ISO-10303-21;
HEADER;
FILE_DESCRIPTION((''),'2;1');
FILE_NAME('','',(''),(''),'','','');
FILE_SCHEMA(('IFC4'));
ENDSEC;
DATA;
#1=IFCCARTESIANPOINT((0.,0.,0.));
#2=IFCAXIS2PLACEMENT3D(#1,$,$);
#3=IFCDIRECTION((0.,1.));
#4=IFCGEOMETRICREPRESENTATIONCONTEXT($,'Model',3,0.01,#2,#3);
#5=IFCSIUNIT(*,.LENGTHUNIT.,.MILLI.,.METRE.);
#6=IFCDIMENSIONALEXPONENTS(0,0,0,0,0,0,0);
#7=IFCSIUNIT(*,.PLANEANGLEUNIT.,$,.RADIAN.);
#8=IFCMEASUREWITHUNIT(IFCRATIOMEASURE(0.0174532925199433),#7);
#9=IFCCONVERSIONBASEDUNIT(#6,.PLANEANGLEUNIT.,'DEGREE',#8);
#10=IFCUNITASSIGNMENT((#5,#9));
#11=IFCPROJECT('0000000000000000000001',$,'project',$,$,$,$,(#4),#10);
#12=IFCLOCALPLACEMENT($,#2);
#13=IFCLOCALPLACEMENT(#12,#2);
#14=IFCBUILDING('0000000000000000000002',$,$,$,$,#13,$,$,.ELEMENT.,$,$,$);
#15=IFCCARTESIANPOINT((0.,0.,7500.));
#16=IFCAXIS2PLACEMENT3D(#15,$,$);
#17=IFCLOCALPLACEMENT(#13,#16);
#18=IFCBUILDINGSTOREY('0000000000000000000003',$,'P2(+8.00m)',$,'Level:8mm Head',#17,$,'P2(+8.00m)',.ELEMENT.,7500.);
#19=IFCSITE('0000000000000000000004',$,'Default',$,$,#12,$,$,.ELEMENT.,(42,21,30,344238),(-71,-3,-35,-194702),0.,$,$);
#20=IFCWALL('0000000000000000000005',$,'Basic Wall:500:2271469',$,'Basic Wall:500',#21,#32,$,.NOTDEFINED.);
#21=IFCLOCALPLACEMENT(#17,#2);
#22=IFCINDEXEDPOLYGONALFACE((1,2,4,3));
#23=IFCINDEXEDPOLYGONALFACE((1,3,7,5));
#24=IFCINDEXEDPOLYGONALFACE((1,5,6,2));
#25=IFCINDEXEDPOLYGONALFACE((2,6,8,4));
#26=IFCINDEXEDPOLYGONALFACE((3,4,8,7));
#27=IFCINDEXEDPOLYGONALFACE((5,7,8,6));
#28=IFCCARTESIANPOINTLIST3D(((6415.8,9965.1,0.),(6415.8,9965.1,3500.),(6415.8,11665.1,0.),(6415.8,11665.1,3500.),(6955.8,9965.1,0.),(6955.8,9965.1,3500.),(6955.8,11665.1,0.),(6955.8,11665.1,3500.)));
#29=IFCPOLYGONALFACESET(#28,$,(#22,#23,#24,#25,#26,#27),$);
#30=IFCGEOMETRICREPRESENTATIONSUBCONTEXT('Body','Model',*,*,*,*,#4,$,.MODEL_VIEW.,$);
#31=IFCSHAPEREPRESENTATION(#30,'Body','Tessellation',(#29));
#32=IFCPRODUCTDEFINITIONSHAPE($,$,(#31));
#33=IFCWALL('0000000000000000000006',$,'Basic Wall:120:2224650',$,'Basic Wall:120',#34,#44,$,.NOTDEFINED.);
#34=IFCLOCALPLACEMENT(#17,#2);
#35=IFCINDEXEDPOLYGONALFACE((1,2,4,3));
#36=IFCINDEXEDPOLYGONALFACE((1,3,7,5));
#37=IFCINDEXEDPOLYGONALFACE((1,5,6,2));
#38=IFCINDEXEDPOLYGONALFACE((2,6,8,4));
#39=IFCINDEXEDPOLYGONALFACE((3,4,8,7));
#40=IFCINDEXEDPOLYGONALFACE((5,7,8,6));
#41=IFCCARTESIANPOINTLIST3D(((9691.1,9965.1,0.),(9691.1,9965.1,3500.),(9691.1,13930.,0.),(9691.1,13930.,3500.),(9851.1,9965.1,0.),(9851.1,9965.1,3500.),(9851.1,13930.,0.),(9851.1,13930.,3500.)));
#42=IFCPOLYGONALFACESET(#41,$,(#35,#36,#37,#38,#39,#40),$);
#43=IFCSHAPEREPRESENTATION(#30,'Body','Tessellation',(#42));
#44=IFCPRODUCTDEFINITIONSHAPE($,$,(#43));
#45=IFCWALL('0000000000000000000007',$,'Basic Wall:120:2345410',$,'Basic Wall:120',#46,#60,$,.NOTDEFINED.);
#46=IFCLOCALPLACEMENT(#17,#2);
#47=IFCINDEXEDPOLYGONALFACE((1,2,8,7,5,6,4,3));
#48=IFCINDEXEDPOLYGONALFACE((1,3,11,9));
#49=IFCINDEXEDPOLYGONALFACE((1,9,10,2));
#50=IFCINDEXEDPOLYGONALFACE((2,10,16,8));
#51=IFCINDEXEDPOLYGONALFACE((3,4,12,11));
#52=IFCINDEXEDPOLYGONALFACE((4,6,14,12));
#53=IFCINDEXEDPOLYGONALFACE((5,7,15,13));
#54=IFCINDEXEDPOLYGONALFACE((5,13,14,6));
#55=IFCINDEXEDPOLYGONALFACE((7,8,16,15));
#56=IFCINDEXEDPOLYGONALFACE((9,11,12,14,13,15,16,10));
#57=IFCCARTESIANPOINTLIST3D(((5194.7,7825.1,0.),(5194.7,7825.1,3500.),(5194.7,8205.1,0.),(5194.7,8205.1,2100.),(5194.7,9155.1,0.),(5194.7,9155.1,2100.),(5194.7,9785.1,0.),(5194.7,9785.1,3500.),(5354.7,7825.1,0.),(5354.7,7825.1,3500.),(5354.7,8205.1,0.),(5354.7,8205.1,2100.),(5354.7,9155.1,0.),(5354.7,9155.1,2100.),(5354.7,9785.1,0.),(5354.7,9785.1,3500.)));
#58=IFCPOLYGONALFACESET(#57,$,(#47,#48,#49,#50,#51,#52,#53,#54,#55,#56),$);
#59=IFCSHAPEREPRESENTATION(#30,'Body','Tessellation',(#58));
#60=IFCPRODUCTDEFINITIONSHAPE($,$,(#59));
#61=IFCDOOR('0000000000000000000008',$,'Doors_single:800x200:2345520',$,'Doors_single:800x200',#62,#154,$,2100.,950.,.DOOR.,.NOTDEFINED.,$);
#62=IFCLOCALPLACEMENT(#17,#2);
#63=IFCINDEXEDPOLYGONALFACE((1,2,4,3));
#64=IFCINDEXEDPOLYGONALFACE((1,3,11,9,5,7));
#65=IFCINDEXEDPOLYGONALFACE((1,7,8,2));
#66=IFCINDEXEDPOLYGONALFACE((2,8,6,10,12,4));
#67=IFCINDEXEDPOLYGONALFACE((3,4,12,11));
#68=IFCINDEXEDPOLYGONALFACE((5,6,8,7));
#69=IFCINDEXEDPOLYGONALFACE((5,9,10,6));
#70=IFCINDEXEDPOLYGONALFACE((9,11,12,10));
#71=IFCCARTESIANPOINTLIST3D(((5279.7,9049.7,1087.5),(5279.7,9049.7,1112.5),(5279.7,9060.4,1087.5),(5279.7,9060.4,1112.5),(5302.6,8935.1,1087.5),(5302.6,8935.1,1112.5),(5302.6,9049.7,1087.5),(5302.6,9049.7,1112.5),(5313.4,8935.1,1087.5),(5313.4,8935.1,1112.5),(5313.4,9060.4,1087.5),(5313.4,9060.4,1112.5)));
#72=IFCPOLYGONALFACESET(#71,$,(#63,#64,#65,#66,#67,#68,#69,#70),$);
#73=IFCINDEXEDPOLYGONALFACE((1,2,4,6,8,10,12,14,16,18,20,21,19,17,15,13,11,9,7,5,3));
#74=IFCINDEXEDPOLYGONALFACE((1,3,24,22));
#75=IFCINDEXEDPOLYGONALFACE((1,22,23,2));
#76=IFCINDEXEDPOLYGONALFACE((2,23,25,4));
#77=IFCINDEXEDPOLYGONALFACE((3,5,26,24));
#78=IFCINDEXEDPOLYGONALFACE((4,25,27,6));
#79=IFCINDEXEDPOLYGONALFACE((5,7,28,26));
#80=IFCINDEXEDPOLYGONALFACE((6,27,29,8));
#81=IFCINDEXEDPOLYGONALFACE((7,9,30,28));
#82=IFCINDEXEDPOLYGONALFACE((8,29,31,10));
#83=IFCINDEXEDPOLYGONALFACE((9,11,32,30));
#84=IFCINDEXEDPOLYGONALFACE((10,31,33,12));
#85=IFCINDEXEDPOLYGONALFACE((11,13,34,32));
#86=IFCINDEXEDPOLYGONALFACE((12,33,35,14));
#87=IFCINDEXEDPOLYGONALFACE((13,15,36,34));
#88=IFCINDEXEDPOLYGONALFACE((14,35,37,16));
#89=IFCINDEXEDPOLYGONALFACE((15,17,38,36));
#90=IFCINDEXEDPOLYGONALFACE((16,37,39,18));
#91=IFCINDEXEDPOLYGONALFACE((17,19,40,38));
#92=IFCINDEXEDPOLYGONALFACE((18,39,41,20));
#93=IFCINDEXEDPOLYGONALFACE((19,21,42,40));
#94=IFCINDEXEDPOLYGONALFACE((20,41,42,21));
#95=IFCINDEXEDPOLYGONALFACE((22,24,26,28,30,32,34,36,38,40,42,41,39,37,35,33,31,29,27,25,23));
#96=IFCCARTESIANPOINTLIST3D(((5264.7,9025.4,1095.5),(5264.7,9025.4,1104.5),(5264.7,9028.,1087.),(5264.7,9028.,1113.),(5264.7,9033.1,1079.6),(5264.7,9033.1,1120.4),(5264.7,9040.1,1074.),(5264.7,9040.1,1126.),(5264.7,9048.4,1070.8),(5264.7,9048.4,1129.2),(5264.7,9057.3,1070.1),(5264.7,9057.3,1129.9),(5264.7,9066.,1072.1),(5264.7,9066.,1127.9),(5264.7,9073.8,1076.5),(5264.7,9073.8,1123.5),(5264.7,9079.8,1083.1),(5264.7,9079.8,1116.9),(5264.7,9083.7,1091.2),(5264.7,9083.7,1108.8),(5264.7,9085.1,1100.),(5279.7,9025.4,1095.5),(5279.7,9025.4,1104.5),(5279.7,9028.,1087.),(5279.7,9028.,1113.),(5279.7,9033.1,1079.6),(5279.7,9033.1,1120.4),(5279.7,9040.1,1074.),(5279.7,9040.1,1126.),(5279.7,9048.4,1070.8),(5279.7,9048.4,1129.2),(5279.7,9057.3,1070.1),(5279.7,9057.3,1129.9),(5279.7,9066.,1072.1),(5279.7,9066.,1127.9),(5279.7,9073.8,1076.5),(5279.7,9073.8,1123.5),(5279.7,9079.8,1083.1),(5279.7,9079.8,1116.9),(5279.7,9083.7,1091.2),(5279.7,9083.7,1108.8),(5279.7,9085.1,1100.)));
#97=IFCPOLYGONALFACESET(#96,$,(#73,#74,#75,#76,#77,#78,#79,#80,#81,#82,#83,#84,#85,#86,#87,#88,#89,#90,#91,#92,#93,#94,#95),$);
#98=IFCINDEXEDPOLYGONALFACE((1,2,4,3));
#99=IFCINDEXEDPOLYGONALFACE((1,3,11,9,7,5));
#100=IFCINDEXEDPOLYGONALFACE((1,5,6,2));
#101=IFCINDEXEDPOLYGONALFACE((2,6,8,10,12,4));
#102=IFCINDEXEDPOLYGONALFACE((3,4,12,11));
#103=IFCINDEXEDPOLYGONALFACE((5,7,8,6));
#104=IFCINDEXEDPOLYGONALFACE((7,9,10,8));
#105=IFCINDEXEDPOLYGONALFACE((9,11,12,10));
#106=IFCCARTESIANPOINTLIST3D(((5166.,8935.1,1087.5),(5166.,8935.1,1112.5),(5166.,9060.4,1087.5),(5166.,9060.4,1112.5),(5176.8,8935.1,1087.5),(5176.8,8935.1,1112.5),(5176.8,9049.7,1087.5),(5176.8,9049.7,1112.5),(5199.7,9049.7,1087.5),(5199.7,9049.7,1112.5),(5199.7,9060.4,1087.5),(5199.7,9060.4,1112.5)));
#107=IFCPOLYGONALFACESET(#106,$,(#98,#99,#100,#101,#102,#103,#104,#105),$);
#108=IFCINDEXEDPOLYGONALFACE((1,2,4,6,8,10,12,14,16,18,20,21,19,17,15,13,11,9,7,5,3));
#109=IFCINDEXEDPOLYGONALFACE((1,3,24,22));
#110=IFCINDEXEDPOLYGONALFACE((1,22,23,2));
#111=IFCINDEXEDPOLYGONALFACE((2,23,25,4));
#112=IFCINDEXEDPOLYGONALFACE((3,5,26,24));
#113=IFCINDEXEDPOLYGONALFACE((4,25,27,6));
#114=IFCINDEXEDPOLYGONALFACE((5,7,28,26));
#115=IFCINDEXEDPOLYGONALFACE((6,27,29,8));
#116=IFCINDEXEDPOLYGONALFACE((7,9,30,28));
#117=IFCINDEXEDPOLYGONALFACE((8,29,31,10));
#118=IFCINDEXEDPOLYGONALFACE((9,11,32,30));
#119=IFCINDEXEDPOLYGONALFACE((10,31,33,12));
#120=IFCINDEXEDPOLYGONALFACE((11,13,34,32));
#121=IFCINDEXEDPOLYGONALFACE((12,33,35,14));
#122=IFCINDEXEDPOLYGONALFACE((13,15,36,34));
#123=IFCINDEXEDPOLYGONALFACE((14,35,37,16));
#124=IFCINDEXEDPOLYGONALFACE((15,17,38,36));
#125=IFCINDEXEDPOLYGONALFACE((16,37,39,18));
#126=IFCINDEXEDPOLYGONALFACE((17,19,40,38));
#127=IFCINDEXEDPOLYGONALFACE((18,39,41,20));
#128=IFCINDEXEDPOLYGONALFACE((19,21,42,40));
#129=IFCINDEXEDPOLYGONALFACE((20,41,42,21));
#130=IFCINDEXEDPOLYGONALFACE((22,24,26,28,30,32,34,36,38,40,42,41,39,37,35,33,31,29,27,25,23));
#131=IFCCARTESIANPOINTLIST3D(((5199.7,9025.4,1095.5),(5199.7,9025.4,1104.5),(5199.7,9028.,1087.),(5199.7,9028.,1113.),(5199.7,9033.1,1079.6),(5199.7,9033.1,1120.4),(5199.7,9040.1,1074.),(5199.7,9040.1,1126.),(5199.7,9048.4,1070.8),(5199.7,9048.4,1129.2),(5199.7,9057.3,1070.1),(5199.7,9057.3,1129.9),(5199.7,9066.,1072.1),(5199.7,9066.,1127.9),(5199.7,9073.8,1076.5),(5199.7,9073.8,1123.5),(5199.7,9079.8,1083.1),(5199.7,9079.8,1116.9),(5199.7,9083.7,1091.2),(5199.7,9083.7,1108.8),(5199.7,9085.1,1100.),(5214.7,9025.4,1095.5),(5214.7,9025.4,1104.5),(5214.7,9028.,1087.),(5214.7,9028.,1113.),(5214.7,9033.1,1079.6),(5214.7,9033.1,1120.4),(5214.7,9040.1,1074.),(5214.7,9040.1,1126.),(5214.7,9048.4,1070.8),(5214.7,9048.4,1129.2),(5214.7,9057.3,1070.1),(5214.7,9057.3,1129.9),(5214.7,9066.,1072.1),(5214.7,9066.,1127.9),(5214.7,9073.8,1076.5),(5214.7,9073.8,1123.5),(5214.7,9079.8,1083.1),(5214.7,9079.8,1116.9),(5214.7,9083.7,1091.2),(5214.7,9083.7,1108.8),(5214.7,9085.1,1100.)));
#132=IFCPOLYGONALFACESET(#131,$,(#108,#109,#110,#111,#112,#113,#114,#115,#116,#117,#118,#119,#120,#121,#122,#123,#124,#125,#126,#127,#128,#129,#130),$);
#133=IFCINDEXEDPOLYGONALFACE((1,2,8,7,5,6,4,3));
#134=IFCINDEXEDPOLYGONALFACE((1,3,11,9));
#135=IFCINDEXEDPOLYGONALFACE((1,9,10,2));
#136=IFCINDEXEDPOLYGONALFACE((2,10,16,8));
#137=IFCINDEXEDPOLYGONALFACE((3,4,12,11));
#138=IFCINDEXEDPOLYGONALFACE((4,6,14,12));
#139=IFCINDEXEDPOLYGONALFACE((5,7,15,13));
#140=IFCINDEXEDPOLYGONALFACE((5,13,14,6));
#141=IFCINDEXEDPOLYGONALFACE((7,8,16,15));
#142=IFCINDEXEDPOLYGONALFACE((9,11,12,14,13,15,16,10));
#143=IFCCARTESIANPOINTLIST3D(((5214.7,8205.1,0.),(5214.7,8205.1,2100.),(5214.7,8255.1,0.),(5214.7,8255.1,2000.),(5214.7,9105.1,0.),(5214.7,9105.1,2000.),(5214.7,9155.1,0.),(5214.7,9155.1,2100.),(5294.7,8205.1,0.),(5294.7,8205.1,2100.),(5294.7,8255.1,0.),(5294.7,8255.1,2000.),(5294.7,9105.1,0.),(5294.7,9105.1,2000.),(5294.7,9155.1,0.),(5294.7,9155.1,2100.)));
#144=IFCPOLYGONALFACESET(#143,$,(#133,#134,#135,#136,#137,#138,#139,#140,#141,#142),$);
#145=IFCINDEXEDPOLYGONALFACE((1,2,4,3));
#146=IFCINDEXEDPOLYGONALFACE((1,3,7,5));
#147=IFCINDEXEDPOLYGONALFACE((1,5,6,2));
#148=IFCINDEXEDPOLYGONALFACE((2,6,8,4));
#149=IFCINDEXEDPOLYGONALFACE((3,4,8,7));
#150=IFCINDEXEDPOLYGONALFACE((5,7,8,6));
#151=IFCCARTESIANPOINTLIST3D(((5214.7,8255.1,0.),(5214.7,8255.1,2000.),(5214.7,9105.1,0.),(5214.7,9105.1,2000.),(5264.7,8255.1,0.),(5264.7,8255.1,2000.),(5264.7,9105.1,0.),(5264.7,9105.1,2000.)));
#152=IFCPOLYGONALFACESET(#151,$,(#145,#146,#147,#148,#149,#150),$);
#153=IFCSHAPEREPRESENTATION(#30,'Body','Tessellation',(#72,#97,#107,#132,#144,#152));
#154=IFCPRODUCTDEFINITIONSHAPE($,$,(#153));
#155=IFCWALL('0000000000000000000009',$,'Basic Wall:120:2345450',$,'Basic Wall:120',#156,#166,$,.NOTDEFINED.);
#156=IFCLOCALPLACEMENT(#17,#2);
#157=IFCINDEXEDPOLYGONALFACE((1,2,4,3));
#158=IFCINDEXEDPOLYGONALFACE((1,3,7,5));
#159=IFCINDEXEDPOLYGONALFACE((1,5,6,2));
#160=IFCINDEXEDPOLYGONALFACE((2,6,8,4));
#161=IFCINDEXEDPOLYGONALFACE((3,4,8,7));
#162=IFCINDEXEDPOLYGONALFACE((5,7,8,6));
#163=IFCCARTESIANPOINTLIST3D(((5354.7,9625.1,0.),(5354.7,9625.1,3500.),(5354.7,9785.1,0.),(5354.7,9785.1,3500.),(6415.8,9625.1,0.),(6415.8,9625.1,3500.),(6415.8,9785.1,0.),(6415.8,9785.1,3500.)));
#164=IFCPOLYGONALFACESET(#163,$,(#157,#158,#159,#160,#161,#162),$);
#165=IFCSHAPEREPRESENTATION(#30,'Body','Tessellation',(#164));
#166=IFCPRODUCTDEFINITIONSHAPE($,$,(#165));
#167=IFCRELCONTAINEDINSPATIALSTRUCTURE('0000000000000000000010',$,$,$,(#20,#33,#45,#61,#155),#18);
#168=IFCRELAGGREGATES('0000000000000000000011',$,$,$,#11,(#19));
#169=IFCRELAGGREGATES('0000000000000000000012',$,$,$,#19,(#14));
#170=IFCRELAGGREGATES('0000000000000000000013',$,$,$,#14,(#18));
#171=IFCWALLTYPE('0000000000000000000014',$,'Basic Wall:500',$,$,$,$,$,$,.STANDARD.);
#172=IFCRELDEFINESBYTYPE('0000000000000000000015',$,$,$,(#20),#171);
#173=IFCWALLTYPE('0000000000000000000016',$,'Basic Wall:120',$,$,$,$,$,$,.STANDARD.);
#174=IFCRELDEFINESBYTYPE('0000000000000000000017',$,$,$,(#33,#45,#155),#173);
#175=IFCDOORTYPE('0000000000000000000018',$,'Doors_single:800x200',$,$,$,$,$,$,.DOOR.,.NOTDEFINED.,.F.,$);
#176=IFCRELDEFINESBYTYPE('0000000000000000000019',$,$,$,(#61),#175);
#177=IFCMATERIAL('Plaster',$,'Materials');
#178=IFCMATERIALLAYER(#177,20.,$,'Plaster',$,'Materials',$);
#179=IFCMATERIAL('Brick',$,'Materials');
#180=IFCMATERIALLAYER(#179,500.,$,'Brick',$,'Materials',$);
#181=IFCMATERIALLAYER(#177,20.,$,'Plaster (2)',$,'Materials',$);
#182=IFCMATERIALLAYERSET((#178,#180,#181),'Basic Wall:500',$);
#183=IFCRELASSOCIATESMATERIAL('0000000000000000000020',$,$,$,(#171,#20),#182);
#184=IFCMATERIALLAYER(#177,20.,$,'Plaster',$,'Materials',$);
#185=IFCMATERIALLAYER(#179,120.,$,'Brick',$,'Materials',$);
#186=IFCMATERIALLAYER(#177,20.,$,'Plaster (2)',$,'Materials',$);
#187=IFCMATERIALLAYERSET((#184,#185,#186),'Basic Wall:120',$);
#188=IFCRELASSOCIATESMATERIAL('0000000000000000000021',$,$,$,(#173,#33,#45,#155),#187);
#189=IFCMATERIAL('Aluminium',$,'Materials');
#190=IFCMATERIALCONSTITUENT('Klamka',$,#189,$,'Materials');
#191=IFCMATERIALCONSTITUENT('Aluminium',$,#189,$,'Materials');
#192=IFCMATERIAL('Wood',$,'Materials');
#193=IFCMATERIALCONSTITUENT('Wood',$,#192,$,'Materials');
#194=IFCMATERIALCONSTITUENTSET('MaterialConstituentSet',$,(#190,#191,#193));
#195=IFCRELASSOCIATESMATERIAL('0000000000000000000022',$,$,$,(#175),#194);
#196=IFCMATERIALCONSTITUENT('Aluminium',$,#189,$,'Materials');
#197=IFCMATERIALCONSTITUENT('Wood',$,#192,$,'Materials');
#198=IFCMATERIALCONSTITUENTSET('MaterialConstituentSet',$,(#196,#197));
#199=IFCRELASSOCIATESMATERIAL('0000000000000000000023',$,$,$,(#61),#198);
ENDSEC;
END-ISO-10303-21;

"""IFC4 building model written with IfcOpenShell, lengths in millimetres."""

from ifc_helpers import new_model, entity, si_unit, converted_unit, direction, frame, frame_2d, origin, origin_2d_with_axis, place, context, subcontext, project, spatial, polyline, rectangle, circle, outline, extrude, source, transform, mapped, material, layer, layer_set, layer_usage, constituent, constituent_set, type_object, type_shapes, element, fill, save


model = new_model("IFC4")

# Units and contexts
model_context = context("Model", 3, precision=0.01, world=origin(), true_north=direction((0.0, 1.0)))
body_context = subcontext(model_context, "Body", "Model", "MODEL_VIEW")
ifc_project = project(units=[si_unit("LENGTHUNIT", "METRE", prefix="MILLI"), converted_unit("PLANEANGLEUNIT", "DEGREE", entity("IfcRatioMeasure", 0.0174532925199433), si_unit("PLANEANGLEUNIT", "RADIAN"), dimensions=[0, 0, 0, 0, 0, 0, 0])], contexts=[model_context])

# Site, building, storey
site_placement = place(None, origin())
site = spatial("IfcSite", under=ifc_project, at=site_placement, Name="Default", CompositionType="ELEMENT", RefLatitude=(42, 21, 30, 344238), RefLongitude=(-71, -3, -35, -194702), RefElevation=0.0)
building_placement = place(site_placement, origin())
building = spatial("IfcBuilding", under=site, at=building_placement, CompositionType="ELEMENT")
storey_placement = place(building_placement, frame((0.0, 0.0, 7500.0)))
storey = spatial("IfcBuildingStorey", under=building, at=storey_placement, Name="P2(+8.00m)", ObjectType="Level:8mm Head", LongName="P2(+8.00m)", CompositionType="ELEMENT", Elevation=7500.0)

# Shared definitions
ifc_material_1 = material(Name="Brick", Category="Materials")
ifc_material_2 = material(Name="Plaster", Category="Materials")

# Shared definitions
ifc_layer_1 = layer(ifc_material_2, 20.0, Name="Plaster", Category="Materials")
ifc_layer_2 = layer(ifc_material_1, 500.0, Name="Brick", Category="Materials")
ifc_layer_3 = layer(ifc_material_2, 20.0, Name="Plaster (2)", Category="Materials")
ifc_layer_set_1 = layer_set([ifc_layer_1, ifc_layer_2, ifc_layer_3], Name="Basic Wall:500")
wall_type_1 = type_object("IfcWallType", Name="Basic Wall:500", PredefinedType="STANDARD", material=ifc_layer_set_1)
ifc_material_3 = material(Name="Aluminium", Category="Materials")
ifc_material_4 = material(Name="Wood", Category="Materials")

# Walls
ifc_layer_usage_1 = layer_usage(ifc_layer_set_1, "AXIS2", "POSITIVE", -270.0)
wall_1_placement = place(storey_placement, frame((6685.8, 11665.1, 0.0), z_axis=(0.0, 0.0, 1.0), x_axis=(0.0, -1.0, 0.0)))
element("IfcWall", 1, at=wall_1_placement, inside=storey, type_object=wall_type_1, material=ifc_layer_usage_1, Name="Basic Wall:500:2271469", ObjectType="Basic Wall:500", PredefinedType="NOTDEFINED", context=body_context, shape_type="SweptSolid", body=[
    extrude(rectangle(XDim=1700.0, YDim=540.0, at=frame_2d((850.0, 0.0), x_axis=(-1.0, 0.0))), origin(), (0.0, 0.0, 1.0), 3500.0),
])
ifc_layer_4 = layer(ifc_material_2, 20.0, Name="Plaster", Category="Materials")
ifc_layer_5 = layer(ifc_material_1, 120.0, Name="Brick", Category="Materials")
ifc_layer_6 = layer(ifc_material_2, 20.0, Name="Plaster (2)", Category="Materials")
ifc_layer_set_2 = layer_set([ifc_layer_4, ifc_layer_5, ifc_layer_6], Name="Basic Wall:120")
ifc_layer_usage_2 = layer_usage(ifc_layer_set_2, "AXIS2", "POSITIVE", -80.0)
wall_type_2 = type_object("IfcWallType", Name="Basic Wall:120", PredefinedType="STANDARD", material=ifc_layer_set_2)
wall_2_placement = place(storey_placement, frame((9771.1, 9965.1, 0.0), z_axis=(0.0, 0.0, 1.0), x_axis=(0.0, 1.0, 0.0)))
element("IfcWall", 2, at=wall_2_placement, inside=storey, type_object=wall_type_2, material=ifc_layer_usage_2, Name="Basic Wall:120:2224650", ObjectType="Basic Wall:120", PredefinedType="NOTDEFINED", context=body_context, shape_type="SweptSolid", body=[
    extrude(rectangle(XDim=3964.9, YDim=160.0, at=frame_2d((1982.5, 0.0), x_axis=(-1.0, 0.0))), origin(), (0.0, 0.0, 1.0), 3500.0),
])

# Wall, opening, door
ifc_layer_usage_3 = layer_usage(ifc_layer_set_2, "AXIS2", "NEGATIVE", 80.0)
wall_3_placement = place(storey_placement, frame((5274.7, 7825.1, 0.0), z_axis=(0.0, 0.0, 1.0), x_axis=(0.0, 1.0, 0.0)))
wall_3 = element("IfcWall", 3, at=wall_3_placement, inside=storey, type_object=wall_type_2, material=ifc_layer_usage_3, Name="Basic Wall:120:2345410", ObjectType="Basic Wall:120", PredefinedType="NOTDEFINED", context=body_context, shape_type="SweptSolid", body=[
    extrude(rectangle(XDim=1960.0, YDim=160.0, at=frame_2d((980.0, 0.0), x_axis=(-1.0, 0.0))), origin(), (0.0, 0.0, 1.0), 3500.0),
])
opening_1_placement = place(wall_3_placement, frame((380.0, -80.0, 0.0)))
opening_1 = element("IfcOpeningElement", 4, at=opening_1_placement, cuts=wall_3, PredefinedType="OPENING", context=body_context, shape_type="SweptSolid", body=[
    extrude(rectangle(XDim=2100.0, YDim=950.0, at=frame_2d((1050.0, 475.0), x_axis=(1.0, 0.0))), frame((0.0, 0.0, 0.0), z_axis=(0.0, 1.0, 0.0), x_axis=(0.0, 0.0, 1.0)), (0.0, 0.0, 1.0), 160.0),
])
ifc_constituent_1 = constituent(ifc_material_3, Name="Aluminium", Category="Materials")
ifc_constituent_2 = constituent(ifc_material_4, Name="Wood", Category="Materials")
ifc_constituent_set_1 = constituent_set(constituents=[ifc_constituent_1, ifc_constituent_2], Name="MaterialConstituentSet")
ifc_constituent_3 = constituent(ifc_material_3, Name="Klamka", Category="Materials")
ifc_constituent_4 = constituent(ifc_material_3, Name="Aluminium", Category="Materials")
ifc_constituent_5 = constituent(ifc_material_4, Name="Wood", Category="Materials")
ifc_constituent_set_2 = constituent_set(constituents=[ifc_constituent_3, ifc_constituent_4, ifc_constituent_5], Name="MaterialConstituentSet")
door_type_1 = type_object("IfcDoorType", Name="Doors_single:800x200", OperationType="NOTDEFINED", ParameterTakesPrecedence=False, PredefinedType="DOOR", material=ifc_constituent_set_2)
shared_shape_1 = source(origin(), body_context, "Body", "SweptSolid", [
    extrude(outline(polyline([(-45.4, -18.9), (-34.6, -18.9), (-34.6, 4.0), (80.0, 4.0), (80.0, 14.8), (-45.4, 14.8), (-45.4, -18.9)])), frame((810.0, 56.1, 1087.5), z_axis=(0.0, 0.0, 1.0), x_axis=(-1.0, 0.0, 0.0)), (0.0, 0.0, 1.0), 25.0),
    extrude(circle(Radius=30.0, at=origin_2d_with_axis()), frame((850.0, 75.0, 1100.0), z_axis=(0.0, 1.0, 0.0), x_axis=(1.0, 0.0, 0.0)), (0.0, 0.0, 1.0), 15.0),
    extrude(outline(polyline([(-18.9, -45.4), (14.8, -45.4), (14.8, 80.0), (4.0, 80.0), (4.0, -34.6), (-18.9, -34.6), (-18.9, -45.4)])), frame((810.0, 173.9, 1087.5), z_axis=(0.0, 0.0, 1.0), x_axis=(0.0, 1.0, 0.0)), (0.0, 0.0, 1.0), 25.0),
    extrude(circle(Radius=30.0, at=origin_2d_with_axis()), frame((850.0, 140.0, 1100.0), z_axis=(0.0, 1.0, 0.0), x_axis=(1.0, 0.0, 0.0)), (0.0, 0.0, 1.0), 15.0),
    extrude(outline(polyline([(-475.0, -1025.0), (-425.0, -1025.0), (-425.0, 975.0), (425.0, 975.0), (425.0, -1025.0), (475.0, -1025.0), (475.0, 1075.0), (-475.0, 1075.0), (-475.0, -1025.0)])), frame((475.0, 60.0, 1025.0), z_axis=(0.0, 1.0, 0.0), x_axis=(-1.0, 0.0, 0.0)), (0.0, 0.0, 1.0), 80.0),
    extrude(rectangle(XDim=850.0, YDim=50.0, at=origin_2d_with_axis()), frame((475.0, 115.0, 0.0), z_axis=(0.0, 0.0, 1.0), x_axis=(-1.0, 0.0, 0.0)), (0.0, 0.0, 1.0), 2000.0),
])
type_shapes(door_type_1, [shared_shape_1])
door_1_placement = place(opening_1_placement, origin())
door_1 = element("IfcDoor", 5, at=door_1_placement, inside=storey, type_object=door_type_1, material=ifc_constituent_set_1, Name="Doors_single:800x200:2345520", ObjectType="Doors_single:800x200", OperationType="NOTDEFINED", OverallHeight=2100.0, OverallWidth=950.0, PredefinedType="DOOR", context=body_context, shape_type="MappedRepresentation", body=[
    mapped(shared_shape_1, transform((0.0, 0.0, 0.0), scale=1.0)),
])
fill(opening_1, door_1)

# Wall
ifc_layer_usage_4 = layer_usage(ifc_layer_set_2, "AXIS2", "NEGATIVE", 80.0)
wall_4_placement = place(storey_placement, frame((5354.7, 9705.1, 0.0)))
element("IfcWall", 6, at=wall_4_placement, inside=storey, type_object=wall_type_2, material=ifc_layer_usage_4, Name="Basic Wall:120:2345450", ObjectType="Basic Wall:120", PredefinedType="NOTDEFINED", context=body_context, shape_type="SweptSolid", body=[
    extrude(rectangle(XDim=1061.1, YDim=160.0, at=frame_2d((530.5, 0.0), x_axis=(-1.0, 0.0))), origin(), (0.0, 0.0, 1.0), 3500.0),
])

save(model, "model.ifc")
